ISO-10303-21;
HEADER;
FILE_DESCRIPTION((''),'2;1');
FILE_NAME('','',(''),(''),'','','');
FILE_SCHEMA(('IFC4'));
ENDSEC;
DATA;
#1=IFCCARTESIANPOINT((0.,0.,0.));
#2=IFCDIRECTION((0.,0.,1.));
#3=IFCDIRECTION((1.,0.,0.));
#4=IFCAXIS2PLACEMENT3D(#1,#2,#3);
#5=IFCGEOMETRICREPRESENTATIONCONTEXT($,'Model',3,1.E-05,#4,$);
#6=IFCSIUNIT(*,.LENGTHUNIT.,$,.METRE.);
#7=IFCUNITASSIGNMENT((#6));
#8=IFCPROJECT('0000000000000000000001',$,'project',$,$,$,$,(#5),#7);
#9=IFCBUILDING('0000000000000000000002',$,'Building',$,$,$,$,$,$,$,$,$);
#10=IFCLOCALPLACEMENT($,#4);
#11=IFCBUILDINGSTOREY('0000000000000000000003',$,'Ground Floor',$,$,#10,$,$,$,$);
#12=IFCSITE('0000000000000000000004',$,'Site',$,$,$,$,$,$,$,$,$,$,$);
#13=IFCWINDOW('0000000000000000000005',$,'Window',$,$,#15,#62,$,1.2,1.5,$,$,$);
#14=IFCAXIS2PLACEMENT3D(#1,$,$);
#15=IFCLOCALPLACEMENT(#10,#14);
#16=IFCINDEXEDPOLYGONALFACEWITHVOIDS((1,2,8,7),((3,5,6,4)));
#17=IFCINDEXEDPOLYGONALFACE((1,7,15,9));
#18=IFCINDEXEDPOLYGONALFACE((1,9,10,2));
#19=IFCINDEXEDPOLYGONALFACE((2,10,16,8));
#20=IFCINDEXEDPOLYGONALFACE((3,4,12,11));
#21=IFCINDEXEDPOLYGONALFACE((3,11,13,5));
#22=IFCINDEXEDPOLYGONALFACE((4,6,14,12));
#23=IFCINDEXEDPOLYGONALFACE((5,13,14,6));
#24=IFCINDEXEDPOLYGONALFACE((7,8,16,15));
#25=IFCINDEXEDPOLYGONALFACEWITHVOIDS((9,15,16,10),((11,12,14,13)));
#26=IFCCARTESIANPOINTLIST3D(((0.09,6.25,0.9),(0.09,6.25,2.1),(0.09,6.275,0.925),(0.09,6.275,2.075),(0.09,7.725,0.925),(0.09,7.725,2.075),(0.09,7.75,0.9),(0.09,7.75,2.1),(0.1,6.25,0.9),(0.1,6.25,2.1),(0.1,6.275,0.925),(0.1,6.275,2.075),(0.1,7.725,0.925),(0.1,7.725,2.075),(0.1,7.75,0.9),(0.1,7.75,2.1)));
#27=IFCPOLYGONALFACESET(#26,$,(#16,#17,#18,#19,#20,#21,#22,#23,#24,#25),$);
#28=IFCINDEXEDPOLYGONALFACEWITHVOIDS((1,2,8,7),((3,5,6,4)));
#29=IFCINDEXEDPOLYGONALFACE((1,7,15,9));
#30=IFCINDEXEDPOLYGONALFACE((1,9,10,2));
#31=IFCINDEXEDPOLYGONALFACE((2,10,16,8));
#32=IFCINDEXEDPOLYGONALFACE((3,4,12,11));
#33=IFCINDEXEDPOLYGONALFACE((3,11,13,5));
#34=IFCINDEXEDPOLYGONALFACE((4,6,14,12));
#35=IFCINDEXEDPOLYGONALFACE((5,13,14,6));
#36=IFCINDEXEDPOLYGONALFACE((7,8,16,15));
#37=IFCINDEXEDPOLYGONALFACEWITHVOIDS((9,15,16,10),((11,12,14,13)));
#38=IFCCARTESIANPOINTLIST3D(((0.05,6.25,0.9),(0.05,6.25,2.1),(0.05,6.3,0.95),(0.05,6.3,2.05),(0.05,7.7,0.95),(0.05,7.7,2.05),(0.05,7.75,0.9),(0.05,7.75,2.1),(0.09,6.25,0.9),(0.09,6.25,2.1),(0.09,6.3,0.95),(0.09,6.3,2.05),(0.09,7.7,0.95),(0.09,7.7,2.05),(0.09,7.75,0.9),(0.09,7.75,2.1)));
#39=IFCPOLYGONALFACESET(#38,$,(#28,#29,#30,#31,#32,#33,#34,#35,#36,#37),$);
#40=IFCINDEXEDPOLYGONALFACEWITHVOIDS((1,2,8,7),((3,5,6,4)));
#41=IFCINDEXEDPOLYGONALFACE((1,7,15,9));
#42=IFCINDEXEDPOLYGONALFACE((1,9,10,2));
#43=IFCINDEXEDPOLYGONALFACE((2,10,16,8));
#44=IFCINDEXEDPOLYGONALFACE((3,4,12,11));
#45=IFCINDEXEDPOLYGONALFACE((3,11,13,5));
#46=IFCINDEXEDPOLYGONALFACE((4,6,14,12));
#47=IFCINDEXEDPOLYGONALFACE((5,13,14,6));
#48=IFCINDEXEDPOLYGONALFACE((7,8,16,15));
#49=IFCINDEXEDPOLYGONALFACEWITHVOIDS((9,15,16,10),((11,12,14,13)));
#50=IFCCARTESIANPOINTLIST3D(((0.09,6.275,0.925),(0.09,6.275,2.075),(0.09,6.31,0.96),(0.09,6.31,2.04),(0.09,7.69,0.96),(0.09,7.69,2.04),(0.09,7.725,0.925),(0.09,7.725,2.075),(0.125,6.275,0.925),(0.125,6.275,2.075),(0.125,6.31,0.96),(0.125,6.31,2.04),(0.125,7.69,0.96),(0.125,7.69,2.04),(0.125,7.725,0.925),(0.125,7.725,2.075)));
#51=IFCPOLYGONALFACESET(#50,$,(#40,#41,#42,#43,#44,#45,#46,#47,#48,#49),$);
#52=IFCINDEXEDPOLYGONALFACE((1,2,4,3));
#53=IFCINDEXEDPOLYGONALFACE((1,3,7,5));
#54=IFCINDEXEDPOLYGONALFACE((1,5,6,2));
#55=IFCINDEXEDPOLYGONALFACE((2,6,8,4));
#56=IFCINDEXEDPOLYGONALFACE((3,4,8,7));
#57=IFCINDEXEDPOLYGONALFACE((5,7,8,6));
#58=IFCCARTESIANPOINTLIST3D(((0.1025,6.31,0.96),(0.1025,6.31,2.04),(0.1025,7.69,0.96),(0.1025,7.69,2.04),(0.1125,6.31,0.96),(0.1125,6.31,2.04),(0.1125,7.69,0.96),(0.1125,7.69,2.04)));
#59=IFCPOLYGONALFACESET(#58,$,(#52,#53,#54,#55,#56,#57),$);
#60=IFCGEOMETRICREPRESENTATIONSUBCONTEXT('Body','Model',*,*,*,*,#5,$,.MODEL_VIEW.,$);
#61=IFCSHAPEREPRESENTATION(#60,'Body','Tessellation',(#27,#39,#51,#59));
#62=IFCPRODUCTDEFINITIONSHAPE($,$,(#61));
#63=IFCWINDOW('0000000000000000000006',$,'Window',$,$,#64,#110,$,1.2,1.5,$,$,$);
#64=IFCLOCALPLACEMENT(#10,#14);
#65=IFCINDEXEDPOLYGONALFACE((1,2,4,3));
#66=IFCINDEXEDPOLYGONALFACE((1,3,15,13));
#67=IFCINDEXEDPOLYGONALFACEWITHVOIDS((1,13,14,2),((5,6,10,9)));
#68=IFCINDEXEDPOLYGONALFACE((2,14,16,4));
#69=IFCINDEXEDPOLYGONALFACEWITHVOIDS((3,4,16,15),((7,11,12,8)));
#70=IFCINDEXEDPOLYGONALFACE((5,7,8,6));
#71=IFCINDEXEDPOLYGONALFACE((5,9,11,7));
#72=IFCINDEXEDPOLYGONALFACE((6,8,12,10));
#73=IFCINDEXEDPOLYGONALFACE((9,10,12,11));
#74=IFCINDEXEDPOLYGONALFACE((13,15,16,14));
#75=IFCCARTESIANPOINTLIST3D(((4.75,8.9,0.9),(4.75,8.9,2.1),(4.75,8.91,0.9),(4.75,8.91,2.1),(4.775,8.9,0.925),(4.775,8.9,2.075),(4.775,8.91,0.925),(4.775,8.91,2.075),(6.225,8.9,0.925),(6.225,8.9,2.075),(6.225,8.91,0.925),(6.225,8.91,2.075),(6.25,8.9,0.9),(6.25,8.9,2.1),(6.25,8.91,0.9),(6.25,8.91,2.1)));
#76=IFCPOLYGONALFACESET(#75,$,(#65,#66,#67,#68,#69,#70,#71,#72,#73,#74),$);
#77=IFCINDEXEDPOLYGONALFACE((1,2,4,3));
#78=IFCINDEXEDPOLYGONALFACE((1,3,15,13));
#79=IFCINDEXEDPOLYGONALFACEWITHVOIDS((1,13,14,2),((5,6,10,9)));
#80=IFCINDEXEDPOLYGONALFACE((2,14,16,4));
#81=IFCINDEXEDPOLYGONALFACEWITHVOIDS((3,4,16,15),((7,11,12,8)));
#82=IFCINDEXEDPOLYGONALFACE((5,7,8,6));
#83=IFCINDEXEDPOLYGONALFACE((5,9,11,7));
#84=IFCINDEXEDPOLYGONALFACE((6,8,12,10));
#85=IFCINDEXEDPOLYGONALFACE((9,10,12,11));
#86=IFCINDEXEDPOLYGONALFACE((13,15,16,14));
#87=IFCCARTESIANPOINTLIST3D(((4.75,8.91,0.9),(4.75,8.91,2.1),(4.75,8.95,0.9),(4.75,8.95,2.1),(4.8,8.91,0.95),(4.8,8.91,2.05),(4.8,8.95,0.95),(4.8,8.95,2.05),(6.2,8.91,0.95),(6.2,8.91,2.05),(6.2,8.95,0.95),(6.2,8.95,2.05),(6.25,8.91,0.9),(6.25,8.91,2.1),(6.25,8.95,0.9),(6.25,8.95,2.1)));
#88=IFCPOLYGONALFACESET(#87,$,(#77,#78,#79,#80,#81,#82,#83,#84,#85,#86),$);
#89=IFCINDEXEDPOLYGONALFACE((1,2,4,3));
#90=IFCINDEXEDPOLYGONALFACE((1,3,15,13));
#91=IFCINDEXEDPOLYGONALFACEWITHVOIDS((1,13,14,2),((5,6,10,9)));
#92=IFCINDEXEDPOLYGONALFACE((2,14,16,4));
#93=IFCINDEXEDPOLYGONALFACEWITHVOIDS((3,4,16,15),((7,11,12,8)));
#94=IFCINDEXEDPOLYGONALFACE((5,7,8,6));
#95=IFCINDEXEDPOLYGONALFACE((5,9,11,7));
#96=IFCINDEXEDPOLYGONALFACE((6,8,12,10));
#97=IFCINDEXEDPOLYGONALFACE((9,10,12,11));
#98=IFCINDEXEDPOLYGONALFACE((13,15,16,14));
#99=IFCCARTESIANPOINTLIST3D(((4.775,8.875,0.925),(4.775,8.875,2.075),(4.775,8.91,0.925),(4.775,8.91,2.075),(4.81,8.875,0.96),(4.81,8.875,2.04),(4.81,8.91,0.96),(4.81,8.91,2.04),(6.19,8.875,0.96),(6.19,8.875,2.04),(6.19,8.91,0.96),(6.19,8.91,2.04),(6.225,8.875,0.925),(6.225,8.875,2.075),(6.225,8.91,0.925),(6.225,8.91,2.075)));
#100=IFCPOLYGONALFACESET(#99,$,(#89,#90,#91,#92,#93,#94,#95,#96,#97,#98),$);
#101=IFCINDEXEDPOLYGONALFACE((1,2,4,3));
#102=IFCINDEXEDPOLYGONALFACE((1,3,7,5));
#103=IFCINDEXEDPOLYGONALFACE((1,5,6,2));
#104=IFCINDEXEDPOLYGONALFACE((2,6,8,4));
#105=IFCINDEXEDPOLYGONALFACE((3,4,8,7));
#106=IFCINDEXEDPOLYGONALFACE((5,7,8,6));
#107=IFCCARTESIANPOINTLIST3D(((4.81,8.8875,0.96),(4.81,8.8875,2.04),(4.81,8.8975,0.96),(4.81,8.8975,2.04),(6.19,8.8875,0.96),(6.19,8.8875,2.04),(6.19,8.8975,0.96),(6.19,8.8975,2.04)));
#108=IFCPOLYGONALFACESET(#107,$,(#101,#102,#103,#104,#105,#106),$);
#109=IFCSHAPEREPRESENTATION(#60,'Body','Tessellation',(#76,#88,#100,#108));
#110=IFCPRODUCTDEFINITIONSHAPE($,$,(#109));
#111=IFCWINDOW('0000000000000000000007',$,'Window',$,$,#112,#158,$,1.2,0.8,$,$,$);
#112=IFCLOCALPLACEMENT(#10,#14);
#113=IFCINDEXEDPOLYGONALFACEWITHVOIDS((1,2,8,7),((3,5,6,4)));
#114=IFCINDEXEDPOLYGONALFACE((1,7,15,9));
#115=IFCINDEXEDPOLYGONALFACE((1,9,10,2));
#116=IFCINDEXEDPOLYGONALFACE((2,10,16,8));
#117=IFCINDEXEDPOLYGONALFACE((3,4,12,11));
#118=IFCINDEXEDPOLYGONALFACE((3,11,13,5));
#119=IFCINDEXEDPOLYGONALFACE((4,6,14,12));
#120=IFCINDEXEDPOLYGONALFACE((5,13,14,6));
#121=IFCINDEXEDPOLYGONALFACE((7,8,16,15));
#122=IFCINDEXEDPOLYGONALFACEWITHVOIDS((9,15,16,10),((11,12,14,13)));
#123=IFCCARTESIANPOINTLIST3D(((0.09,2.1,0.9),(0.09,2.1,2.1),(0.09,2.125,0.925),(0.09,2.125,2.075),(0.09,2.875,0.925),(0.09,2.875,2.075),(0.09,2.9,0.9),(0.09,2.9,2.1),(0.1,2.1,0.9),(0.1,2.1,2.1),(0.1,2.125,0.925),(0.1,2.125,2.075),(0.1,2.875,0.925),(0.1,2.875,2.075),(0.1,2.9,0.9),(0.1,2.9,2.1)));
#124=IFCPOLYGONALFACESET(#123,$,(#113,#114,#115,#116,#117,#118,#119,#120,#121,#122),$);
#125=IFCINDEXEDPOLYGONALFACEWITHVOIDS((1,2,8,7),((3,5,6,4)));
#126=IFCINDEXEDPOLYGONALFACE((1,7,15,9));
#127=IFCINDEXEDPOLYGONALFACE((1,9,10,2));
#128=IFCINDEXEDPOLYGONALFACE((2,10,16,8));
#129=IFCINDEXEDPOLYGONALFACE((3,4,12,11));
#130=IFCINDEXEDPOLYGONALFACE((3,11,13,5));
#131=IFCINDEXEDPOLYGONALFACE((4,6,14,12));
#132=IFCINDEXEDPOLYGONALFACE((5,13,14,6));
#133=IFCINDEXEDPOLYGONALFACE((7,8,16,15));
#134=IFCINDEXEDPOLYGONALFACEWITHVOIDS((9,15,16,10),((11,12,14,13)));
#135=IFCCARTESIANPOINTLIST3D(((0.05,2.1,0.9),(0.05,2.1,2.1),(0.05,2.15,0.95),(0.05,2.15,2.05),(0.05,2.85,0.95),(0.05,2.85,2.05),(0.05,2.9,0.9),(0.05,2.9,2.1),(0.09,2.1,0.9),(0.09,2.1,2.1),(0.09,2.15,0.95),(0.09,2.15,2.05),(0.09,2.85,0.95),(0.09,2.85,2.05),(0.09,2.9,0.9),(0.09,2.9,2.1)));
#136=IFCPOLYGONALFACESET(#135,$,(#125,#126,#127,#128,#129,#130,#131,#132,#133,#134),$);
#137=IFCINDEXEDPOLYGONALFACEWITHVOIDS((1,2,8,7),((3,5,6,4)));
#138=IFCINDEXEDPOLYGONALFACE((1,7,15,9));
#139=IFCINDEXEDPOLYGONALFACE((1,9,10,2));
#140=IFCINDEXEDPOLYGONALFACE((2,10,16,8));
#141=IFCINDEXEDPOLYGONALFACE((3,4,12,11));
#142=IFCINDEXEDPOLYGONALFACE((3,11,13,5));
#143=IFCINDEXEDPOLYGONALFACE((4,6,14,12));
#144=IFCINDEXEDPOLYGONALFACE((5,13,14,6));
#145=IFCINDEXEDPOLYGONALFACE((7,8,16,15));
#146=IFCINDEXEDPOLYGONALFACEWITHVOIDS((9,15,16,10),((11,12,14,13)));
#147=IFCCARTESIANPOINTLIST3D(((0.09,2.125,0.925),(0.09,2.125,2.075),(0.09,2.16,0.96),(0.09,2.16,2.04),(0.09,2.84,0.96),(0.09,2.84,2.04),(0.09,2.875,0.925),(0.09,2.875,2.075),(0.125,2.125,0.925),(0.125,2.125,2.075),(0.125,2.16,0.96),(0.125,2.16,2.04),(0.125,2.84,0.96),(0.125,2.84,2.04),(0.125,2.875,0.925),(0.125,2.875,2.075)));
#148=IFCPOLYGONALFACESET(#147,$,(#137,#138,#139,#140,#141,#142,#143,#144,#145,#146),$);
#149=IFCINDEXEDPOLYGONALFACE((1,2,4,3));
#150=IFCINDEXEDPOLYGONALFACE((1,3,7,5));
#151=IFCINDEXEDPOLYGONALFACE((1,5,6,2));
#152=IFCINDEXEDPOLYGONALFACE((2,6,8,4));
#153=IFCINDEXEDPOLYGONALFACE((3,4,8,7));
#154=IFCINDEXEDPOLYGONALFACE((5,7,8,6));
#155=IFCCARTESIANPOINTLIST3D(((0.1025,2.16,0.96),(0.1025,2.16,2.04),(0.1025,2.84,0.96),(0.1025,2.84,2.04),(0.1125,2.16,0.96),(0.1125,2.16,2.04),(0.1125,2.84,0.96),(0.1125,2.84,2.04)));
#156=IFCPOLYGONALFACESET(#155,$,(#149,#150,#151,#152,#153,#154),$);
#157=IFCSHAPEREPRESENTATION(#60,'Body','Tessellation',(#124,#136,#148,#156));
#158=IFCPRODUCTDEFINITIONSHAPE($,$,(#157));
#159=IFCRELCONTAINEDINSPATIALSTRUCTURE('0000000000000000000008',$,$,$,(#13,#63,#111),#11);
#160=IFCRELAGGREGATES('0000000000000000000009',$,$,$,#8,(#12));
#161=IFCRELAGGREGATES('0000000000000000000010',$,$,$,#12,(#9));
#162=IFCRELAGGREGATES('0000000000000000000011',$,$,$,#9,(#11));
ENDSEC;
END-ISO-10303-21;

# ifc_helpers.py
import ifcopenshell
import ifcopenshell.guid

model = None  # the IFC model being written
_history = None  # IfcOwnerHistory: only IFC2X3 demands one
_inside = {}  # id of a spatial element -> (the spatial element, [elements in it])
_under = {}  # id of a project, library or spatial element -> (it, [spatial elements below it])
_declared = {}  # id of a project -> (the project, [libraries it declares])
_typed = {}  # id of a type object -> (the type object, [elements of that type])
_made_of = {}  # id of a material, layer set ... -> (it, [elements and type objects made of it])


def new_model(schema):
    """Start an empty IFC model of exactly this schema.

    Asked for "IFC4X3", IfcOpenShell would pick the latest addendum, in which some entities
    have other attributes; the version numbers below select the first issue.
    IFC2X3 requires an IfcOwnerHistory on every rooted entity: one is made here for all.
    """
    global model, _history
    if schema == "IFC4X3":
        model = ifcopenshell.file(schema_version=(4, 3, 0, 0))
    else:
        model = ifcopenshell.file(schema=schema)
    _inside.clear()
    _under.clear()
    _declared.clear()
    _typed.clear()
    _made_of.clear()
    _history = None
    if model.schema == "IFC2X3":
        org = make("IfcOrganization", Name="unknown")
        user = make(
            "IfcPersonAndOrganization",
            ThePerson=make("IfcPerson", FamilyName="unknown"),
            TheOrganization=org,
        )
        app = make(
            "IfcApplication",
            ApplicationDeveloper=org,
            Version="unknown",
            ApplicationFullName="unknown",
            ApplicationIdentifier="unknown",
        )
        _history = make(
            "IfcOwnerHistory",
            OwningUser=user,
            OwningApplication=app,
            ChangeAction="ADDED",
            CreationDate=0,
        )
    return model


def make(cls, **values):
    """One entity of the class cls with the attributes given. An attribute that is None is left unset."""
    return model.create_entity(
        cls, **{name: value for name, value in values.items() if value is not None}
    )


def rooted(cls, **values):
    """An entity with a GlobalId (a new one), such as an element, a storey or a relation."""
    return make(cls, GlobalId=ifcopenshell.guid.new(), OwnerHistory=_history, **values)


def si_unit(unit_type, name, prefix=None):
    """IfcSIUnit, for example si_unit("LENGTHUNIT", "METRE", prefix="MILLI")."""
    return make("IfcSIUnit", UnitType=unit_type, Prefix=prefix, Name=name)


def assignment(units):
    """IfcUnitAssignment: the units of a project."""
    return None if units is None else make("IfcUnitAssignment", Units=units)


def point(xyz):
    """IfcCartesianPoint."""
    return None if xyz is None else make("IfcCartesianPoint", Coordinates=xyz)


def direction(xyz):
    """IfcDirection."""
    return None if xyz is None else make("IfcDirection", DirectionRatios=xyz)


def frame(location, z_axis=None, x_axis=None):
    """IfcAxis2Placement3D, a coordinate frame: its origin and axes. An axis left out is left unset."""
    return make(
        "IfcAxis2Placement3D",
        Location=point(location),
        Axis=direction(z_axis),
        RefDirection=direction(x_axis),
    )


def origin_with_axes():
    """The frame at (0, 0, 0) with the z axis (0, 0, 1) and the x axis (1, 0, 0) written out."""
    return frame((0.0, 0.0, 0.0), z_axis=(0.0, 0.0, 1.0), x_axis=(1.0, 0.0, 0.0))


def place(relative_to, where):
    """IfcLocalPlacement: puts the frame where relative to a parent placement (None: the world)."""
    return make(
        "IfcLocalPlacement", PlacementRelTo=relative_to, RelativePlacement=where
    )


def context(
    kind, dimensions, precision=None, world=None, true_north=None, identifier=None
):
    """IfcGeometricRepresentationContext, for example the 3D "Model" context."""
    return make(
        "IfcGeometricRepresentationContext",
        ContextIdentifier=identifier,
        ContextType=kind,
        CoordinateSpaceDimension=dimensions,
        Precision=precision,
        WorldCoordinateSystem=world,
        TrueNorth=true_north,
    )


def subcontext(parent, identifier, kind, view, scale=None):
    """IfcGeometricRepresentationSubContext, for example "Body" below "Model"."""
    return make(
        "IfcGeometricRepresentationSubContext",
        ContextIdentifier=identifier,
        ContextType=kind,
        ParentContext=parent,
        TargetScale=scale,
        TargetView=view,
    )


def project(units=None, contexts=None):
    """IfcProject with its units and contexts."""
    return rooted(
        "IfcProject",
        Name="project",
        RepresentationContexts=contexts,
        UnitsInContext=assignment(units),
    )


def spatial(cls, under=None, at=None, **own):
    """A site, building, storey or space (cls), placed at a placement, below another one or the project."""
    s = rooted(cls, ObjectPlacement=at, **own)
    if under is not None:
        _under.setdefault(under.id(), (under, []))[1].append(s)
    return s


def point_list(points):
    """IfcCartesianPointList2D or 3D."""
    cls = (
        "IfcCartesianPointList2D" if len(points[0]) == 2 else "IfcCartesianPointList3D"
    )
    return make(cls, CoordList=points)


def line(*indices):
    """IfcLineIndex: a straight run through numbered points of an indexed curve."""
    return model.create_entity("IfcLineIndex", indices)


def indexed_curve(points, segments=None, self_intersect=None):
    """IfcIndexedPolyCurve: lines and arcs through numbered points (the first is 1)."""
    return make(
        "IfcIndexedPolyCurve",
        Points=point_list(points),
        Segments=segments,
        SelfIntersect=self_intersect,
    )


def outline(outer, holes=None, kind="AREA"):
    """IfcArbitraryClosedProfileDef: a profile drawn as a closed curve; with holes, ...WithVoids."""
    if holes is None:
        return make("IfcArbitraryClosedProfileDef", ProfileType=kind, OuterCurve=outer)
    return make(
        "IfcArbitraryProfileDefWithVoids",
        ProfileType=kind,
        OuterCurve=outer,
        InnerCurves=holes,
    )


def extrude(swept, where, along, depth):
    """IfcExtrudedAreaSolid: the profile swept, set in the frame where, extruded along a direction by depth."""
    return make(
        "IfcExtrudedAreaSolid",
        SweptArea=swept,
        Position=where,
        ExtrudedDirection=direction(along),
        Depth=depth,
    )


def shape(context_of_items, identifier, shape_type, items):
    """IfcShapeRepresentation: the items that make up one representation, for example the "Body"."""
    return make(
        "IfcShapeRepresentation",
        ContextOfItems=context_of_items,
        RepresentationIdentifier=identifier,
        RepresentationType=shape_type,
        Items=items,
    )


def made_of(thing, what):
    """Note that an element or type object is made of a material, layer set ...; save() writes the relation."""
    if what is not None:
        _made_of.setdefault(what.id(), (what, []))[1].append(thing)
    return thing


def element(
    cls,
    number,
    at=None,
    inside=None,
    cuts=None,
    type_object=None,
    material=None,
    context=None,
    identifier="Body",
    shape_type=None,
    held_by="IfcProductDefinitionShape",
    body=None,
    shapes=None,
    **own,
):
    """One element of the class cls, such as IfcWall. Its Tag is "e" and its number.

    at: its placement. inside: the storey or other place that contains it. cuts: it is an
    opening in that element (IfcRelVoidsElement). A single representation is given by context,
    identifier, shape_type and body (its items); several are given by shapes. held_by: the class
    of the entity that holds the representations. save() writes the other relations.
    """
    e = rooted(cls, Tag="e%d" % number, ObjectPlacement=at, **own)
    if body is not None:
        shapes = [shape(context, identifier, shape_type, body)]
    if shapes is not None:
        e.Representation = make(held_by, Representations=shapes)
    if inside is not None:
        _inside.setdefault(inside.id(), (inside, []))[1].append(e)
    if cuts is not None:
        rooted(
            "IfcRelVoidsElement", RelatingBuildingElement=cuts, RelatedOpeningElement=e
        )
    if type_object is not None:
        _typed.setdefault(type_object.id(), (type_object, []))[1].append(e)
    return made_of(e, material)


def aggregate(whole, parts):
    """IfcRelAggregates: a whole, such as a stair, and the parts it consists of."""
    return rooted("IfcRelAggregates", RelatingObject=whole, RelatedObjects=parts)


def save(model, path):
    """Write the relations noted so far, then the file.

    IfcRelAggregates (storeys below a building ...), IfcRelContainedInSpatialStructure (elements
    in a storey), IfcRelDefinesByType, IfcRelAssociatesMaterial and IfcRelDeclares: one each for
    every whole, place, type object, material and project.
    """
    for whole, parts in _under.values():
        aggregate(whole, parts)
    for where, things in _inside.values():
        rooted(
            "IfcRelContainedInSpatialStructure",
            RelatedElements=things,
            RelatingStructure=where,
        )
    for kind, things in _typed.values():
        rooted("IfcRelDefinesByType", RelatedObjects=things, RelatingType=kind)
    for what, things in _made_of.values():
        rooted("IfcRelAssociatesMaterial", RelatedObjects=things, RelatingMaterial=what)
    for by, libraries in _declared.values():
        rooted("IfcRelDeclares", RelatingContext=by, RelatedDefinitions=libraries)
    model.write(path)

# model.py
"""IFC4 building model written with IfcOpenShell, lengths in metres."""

from ifc_helpers import new_model, si_unit, frame, origin_with_axes, place, context, subcontext, project, spatial, line, indexed_curve, outline, extrude, element, save


model = new_model("IFC4")

# Units and contexts
model_context = context("Model", 3, precision=1e-05, world=origin_with_axes())
body_context = subcontext(model_context, "Body", "Model", "MODEL_VIEW")
ifc_project = project(units=[si_unit("LENGTHUNIT", "METRE")], contexts=[model_context])

# Site, building, storey
site = spatial("IfcSite", under=ifc_project, Name="Site")
building = spatial("IfcBuilding", under=site, Name="Building")
storey_placement = place(None, origin_with_axes())
storey = spatial("IfcBuildingStorey", under=building, at=storey_placement, Name="Ground Floor")

# Windows
for number, where, z_axis, x_axis, name in (
    (1, (0.0, 7.75, 0.9), (0.0, 0.0, 1.0), (0.0, -1.0, 0.0), "Window"),
    (2, (6.25, 9.0, 0.9), (0.0, 0.0, 1.0), (-1.0, 0.0, 0.0), "Window"),
):
    element("IfcWindow", number, at=place(storey_placement, frame(where, z_axis=z_axis, x_axis=x_axis)), inside=storey, Name=name, OverallHeight=1.2, OverallWidth=1.5, context=body_context, shape_type="SweptSolid", body=[
        extrude(outline(indexed_curve([(0.0, 0.0), (1.5, 0.0), (1.5, 1.2), (0.0, 1.2)], segments=[line(1, 2, 3, 4, 1)]), holes=[indexed_curve([(0.025, 0.025), (1.475, 0.025), (1.475, 1.175), (0.025, 1.175)], segments=[line(1, 2, 3, 4, 1)])]), frame((0.0, 0.09, 0.0), z_axis=(0.0, -1.0, 0.0), x_axis=(1.0, 0.0, 0.0)), (0.0, 0.0, -1.0), 0.01),
        extrude(outline(indexed_curve([(0.0, 0.0), (1.5, 0.0), (1.5, 1.2), (0.0, 1.2)], segments=[line(1, 2, 3, 4, 1)]), holes=[indexed_curve([(0.05, 0.05), (1.45, 0.05), (1.45, 1.15), (0.05, 1.15)], segments=[line(1, 2, 3, 4, 1)])]), frame((0.0, 0.05, 0.0), z_axis=(0.0, -1.0, 0.0), x_axis=(1.0, 0.0, 0.0)), (0.0, 0.0, -1.0), 0.04),
        extrude(outline(indexed_curve([(0.0, 0.0), (1.45, 0.0), (1.45, 1.15), (0.0, 1.15)], segments=[line(1, 2, 3, 4, 1)]), holes=[indexed_curve([(0.035, 0.035), (1.415, 0.035), (1.415, 1.115), (0.035, 1.115)], segments=[line(1, 2, 3, 4, 1)])]), frame((0.025, 0.09, 0.025), z_axis=(0.0, -1.0, 0.0), x_axis=(1.0, 0.0, 0.0)), (0.0, 0.0, -1.0), 0.035),
        extrude(outline(indexed_curve([(0.035, 0.035), (1.415, 0.035), (1.415, 1.115), (0.035, 1.115)], segments=[line(1, 2, 3, 4, 1)])), frame((0.025, 0.1025, 0.025), z_axis=(0.0, -1.0, 0.0), x_axis=(1.0, 0.0, 0.0)), (0.0, 0.0, -1.0), 0.01),
    ])
window_1_placement = place(storey_placement, frame((0.0, 2.9, 0.9), z_axis=(0.0, 0.0, 1.0), x_axis=(0.0, -1.0, 0.0)))
element("IfcWindow", 3, at=window_1_placement, inside=storey, Name="Window", OverallHeight=1.2, OverallWidth=0.8, context=body_context, shape_type="SweptSolid", body=[
    extrude(outline(indexed_curve([(0.0, 0.0), (0.8, 0.0), (0.8, 1.2), (0.0, 1.2)], segments=[line(1, 2, 3, 4, 1)]), holes=[indexed_curve([(0.025, 0.025), (0.775, 0.025), (0.775, 1.175), (0.025, 1.175)], segments=[line(1, 2, 3, 4, 1)])]), frame((0.0, 0.09, 0.0), z_axis=(0.0, -1.0, 0.0), x_axis=(1.0, 0.0, 0.0)), (0.0, 0.0, -1.0), 0.01),
    extrude(outline(indexed_curve([(0.0, 0.0), (0.8, 0.0), (0.8, 1.2), (0.0, 1.2)], segments=[line(1, 2, 3, 4, 1)]), holes=[indexed_curve([(0.05, 0.05), (0.75, 0.05), (0.75, 1.15), (0.05, 1.15)], segments=[line(1, 2, 3, 4, 1)])]), frame((0.0, 0.05, 0.0), z_axis=(0.0, -1.0, 0.0), x_axis=(1.0, 0.0, 0.0)), (0.0, 0.0, -1.0), 0.04),
    extrude(outline(indexed_curve([(0.0, 0.0), (0.75, 0.0), (0.75, 1.15), (0.0, 1.15)], segments=[line(1, 2, 3, 4, 1)]), holes=[indexed_curve([(0.035, 0.035), (0.715, 0.035), (0.715, 1.115), (0.035, 1.115)], segments=[line(1, 2, 3, 4, 1)])]), frame((0.025, 0.09, 0.025), z_axis=(0.0, -1.0, 0.0), x_axis=(1.0, 0.0, 0.0)), (0.0, 0.0, -1.0), 0.035),
    extrude(outline(indexed_curve([(0.035, 0.035), (0.715, 0.035), (0.715, 1.115), (0.035, 1.115)], segments=[line(1, 2, 3, 4, 1)])), frame((0.025, 0.1025, 0.025), z_axis=(0.0, -1.0, 0.0), x_axis=(1.0, 0.0, 0.0)), (0.0, 0.0, -1.0), 0.01),
])

save(model, "model.ifc")
